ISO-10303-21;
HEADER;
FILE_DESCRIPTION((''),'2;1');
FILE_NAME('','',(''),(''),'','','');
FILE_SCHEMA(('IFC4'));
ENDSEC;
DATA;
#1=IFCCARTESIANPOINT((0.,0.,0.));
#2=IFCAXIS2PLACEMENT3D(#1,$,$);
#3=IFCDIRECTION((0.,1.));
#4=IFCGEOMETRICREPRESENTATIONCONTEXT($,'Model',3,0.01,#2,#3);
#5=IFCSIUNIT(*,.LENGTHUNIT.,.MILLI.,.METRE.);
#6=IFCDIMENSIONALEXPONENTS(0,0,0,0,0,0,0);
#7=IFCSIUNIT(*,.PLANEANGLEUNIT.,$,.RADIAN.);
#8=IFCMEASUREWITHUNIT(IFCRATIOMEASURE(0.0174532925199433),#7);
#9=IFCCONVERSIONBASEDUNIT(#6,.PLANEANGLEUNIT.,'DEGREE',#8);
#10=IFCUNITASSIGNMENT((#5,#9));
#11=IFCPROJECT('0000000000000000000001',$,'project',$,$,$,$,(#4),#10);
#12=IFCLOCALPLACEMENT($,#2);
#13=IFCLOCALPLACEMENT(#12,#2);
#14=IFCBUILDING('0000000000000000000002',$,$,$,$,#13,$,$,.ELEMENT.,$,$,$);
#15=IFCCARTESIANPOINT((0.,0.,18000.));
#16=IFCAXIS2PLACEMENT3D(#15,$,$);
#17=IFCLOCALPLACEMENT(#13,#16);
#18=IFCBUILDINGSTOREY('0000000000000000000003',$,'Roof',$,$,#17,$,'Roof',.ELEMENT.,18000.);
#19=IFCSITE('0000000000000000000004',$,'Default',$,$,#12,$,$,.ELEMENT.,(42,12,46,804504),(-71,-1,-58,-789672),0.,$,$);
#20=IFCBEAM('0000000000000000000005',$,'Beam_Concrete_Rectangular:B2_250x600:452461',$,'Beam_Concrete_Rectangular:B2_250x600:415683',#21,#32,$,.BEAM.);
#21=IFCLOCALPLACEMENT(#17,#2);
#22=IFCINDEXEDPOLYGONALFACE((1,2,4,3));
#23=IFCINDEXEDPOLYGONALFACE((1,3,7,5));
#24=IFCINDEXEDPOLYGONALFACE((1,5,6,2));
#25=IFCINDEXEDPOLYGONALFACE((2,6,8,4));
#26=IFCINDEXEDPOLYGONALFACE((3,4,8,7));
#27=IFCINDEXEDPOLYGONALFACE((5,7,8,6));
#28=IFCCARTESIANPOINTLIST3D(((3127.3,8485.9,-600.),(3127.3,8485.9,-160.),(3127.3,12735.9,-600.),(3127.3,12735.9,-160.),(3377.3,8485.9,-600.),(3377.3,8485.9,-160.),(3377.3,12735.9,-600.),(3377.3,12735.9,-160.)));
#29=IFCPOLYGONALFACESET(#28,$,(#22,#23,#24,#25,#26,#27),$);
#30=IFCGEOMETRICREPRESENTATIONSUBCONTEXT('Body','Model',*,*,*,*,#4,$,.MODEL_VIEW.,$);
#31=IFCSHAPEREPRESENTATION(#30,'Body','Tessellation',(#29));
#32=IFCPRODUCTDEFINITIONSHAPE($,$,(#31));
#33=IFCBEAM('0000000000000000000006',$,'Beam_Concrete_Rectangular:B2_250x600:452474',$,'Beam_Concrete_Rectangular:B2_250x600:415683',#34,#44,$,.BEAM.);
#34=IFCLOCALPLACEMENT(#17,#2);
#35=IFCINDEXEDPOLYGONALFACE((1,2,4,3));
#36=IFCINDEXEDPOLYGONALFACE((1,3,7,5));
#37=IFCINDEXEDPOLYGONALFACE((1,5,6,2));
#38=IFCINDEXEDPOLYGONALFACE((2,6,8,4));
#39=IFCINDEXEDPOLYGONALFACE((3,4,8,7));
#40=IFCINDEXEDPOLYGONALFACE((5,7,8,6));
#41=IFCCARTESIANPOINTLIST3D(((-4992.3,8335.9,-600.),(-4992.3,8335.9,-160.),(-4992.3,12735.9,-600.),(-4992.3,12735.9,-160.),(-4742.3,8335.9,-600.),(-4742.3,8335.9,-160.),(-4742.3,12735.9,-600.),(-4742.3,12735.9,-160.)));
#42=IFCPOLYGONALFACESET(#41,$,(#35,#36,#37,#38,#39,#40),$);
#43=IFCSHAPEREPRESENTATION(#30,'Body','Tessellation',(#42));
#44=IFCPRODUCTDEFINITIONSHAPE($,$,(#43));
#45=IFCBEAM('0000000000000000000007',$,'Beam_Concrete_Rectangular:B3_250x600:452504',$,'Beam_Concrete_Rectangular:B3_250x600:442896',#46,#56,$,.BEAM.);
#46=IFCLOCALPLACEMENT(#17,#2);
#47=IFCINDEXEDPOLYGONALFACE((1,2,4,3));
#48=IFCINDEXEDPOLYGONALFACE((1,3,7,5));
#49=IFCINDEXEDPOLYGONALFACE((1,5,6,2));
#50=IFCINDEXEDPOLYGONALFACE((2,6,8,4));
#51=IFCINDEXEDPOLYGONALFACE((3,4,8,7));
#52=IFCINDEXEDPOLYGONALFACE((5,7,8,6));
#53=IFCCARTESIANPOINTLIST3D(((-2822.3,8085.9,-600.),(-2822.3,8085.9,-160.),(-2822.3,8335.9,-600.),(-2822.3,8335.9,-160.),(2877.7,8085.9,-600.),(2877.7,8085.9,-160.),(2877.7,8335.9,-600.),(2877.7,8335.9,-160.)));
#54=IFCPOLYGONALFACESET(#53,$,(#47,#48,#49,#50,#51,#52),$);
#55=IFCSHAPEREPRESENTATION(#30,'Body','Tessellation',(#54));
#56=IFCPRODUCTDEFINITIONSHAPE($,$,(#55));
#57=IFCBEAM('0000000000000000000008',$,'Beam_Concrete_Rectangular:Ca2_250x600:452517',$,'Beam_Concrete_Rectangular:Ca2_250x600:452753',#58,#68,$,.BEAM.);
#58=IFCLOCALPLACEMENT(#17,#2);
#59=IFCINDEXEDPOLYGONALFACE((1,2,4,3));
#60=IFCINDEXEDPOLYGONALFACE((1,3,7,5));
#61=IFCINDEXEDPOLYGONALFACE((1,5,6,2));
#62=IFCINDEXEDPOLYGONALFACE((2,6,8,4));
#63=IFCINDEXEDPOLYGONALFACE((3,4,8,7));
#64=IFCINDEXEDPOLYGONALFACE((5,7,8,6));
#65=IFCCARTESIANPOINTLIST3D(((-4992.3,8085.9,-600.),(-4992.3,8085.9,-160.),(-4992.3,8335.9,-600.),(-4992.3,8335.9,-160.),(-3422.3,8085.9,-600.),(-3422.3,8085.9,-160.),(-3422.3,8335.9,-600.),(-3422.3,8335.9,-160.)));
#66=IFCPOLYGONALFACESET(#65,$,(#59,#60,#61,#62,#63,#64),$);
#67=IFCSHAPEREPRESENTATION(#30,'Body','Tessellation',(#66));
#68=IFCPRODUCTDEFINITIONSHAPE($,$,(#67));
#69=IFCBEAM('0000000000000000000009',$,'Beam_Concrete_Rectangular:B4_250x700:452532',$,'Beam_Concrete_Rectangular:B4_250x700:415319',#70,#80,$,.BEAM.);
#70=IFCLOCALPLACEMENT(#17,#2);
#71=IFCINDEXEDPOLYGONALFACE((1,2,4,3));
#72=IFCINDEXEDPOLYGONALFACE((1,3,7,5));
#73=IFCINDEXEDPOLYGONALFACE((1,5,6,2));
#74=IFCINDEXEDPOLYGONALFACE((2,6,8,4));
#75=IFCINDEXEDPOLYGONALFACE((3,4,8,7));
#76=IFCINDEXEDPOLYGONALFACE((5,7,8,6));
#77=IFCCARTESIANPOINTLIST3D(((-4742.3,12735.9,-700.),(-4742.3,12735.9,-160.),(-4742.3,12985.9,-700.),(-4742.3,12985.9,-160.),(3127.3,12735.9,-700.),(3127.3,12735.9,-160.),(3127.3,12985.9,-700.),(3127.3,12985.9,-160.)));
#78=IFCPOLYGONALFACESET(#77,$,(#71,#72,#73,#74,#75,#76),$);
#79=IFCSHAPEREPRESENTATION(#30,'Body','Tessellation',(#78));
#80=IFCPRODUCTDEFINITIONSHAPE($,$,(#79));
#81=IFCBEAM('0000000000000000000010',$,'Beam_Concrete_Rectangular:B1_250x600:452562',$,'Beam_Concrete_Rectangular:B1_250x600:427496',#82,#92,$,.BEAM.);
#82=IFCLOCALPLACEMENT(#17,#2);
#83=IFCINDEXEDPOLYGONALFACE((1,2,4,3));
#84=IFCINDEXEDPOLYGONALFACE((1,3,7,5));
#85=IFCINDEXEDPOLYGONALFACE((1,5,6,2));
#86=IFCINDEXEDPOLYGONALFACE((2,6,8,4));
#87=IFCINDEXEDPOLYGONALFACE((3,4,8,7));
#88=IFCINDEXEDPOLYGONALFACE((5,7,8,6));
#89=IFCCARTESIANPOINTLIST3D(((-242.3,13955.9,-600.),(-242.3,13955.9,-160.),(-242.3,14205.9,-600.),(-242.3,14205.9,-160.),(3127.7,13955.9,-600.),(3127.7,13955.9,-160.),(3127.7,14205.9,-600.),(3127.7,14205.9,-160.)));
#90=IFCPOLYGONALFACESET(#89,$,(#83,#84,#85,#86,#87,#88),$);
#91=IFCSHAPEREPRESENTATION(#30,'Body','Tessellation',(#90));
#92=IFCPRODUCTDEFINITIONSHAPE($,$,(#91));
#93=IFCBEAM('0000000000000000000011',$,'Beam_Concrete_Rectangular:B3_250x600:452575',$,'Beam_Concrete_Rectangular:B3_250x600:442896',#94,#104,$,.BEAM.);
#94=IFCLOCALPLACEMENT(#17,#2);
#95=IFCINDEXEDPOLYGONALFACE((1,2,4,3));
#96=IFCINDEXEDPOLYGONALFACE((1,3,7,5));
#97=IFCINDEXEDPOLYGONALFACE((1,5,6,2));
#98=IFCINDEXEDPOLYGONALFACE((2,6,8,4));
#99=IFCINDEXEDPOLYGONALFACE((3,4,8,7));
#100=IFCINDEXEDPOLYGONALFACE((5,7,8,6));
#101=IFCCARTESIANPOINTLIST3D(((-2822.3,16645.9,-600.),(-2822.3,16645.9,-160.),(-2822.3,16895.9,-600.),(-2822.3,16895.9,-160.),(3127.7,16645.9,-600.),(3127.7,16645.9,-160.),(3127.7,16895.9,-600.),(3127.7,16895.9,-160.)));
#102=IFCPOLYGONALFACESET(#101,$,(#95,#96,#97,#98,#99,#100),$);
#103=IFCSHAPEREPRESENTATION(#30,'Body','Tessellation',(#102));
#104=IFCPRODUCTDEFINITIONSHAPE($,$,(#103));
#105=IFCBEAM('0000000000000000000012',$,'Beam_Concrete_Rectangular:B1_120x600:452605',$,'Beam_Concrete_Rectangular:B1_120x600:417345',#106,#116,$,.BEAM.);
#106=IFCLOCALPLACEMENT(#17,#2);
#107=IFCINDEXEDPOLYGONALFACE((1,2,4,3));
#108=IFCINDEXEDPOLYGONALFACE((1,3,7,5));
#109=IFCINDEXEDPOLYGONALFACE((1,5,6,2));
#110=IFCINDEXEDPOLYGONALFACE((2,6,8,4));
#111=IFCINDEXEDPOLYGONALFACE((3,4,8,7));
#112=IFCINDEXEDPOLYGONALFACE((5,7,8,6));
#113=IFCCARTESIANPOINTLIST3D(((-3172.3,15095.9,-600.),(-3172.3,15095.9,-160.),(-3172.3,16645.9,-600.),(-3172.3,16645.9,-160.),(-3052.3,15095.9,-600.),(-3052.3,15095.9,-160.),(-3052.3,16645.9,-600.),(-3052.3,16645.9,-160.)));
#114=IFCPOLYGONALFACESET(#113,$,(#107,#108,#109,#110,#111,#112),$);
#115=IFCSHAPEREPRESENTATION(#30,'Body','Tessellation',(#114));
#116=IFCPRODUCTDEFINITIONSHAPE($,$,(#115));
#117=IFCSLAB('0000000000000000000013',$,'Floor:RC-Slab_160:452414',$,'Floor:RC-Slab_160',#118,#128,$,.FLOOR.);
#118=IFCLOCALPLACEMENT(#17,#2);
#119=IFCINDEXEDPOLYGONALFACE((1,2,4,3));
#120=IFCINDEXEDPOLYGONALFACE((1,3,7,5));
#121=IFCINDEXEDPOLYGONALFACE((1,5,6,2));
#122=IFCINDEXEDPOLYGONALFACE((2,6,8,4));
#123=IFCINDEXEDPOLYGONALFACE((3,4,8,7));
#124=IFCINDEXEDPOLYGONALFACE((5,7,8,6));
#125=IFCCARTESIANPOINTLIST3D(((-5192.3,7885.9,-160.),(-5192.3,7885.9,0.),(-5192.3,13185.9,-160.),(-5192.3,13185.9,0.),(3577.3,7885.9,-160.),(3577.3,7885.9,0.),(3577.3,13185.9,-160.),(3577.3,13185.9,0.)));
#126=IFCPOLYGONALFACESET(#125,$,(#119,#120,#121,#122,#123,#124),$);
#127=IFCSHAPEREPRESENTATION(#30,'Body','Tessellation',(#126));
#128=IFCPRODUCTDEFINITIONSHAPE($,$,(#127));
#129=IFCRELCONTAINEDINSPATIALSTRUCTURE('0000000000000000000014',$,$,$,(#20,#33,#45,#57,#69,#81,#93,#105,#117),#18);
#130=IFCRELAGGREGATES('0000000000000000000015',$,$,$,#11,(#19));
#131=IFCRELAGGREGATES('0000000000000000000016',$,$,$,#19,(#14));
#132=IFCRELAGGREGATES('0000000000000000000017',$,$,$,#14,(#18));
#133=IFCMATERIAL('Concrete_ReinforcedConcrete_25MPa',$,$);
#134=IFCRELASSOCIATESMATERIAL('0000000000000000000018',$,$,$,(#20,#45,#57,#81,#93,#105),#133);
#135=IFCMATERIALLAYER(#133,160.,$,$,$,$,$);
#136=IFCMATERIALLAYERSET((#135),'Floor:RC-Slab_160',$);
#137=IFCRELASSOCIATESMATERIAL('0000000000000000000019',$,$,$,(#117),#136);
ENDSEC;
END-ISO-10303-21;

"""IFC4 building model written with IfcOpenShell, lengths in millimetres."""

from ifc_helpers import new_model, entity, si_unit, converted_unit, direction, frame, frame_2d, origin, place, context, subcontext, project, spatial, rectangle, extrude, material, layer, layer_set, layer_usage, element, save


model = new_model("IFC4")

# Units and contexts
model_context = context("Model", 3, precision=0.01, world=origin(), true_north=direction((0.0, 1.0)))
body_context = subcontext(model_context, "Body", "Model", "MODEL_VIEW")
ifc_project = project(units=[si_unit("LENGTHUNIT", "METRE", prefix="MILLI"), converted_unit("PLANEANGLEUNIT", "DEGREE", entity("IfcRatioMeasure", 0.0174532925199433), si_unit("PLANEANGLEUNIT", "RADIAN"), dimensions=[0, 0, 0, 0, 0, 0, 0])], contexts=[model_context])

# Site, building, storey
site_placement = place(None, origin())
site = spatial("IfcSite", under=ifc_project, at=site_placement, Name="Default", CompositionType="ELEMENT", RefLatitude=(42, 12, 46, 804504), RefLongitude=(-71, -1, -58, -789672), RefElevation=0.0)
building_placement = place(site_placement, origin())
building = spatial("IfcBuilding", under=site, at=building_placement, CompositionType="ELEMENT")
storey_placement = place(building_placement, frame((0.0, 0.0, 18000.0)))
storey = spatial("IfcBuildingStorey", under=building, at=storey_placement, Name="Roof", LongName="Roof", CompositionType="ELEMENT", Elevation=18000.0)

# Beams
ifc_material = material(Name="Concrete_ReinforcedConcrete_25MPa")
beam_1_placement = place(storey_placement, frame((3127.3, 12860.9, 0.0), z_axis=(0.0, 0.0, 1.0), x_axis=(0.0, -1.0, 0.0)))
element("IfcBeam", 1, at=beam_1_placement, inside=storey, material=ifc_material, Name="Beam_Concrete_Rectangular:B2_250x600:452461", ObjectType="Beam_Concrete_Rectangular:B2_250x600:415683", PredefinedType="BEAM", context=body_context, shape_type="SweptSolid", body=[
    extrude(rectangle(XDim=440.0, YDim=250.0, at=frame_2d((0.0, 0.0), x_axis=(1.0, 0.0))), frame((125.0, 125.0, -380.0), z_axis=(1.0, 0.0, 0.0), x_axis=(0.0, 0.0, -1.0)), (0.0, 0.0, 1.0), 4250.0),
])
beam_2_placement = place(storey_placement, frame((-4742.3, 8335.9, 0.0), z_axis=(0.0, 0.0, 1.0), x_axis=(0.0, 1.0, 0.0)))
element("IfcBeam", 2, at=beam_2_placement, inside=storey, Name="Beam_Concrete_Rectangular:B2_250x600:452474", ObjectType="Beam_Concrete_Rectangular:B2_250x600:415683", PredefinedType="BEAM", context=body_context, shape_type="SweptSolid", body=[
    extrude(rectangle(XDim=440.0, YDim=250.0, at=frame_2d((0.0, 0.0), x_axis=(1.0, 0.0))), frame((0.0, 125.0, -380.0), z_axis=(1.0, 0.0, 0.0), x_axis=(0.0, 0.0, -1.0)), (0.0, 0.0, 1.0), 4400.0),
])
beam_3_placement = place(storey_placement, frame((-3122.3, 8085.9, 0.0)))
element("IfcBeam", 3, at=beam_3_placement, inside=storey, material=ifc_material, Name="Beam_Concrete_Rectangular:B3_250x600:452504", ObjectType="Beam_Concrete_Rectangular:B3_250x600:442896", PredefinedType="BEAM", context=body_context, shape_type="SweptSolid", body=[
    extrude(rectangle(XDim=440.0, YDim=250.0, at=frame_2d((0.0, 0.0), x_axis=(1.0, 0.0))), frame((300.0, 125.0, -380.0), z_axis=(1.0, 0.0, 0.0), x_axis=(0.0, 0.0, -1.0)), (0.0, 0.0, 1.0), 5700.0),
])
beam_4_placement = place(storey_placement, frame((-4992.3, 8085.9, 0.0)))
element("IfcBeam", 4, at=beam_4_placement, inside=storey, material=ifc_material, Name="Beam_Concrete_Rectangular:Ca2_250x600:452517", ObjectType="Beam_Concrete_Rectangular:Ca2_250x600:452753", PredefinedType="BEAM", context=body_context, shape_type="SweptSolid", body=[
    extrude(rectangle(XDim=440.0, YDim=250.0, at=frame_2d((0.0, 0.0), x_axis=(1.0, 0.0))), frame((0.0, 125.0, -380.0), z_axis=(1.0, 0.0, 0.0), x_axis=(0.0, 0.0, -1.0)), (0.0, 0.0, 1.0), 1570.0),
])
beam_5_placement = place(storey_placement, frame((-4867.3, 12735.9, 0.0)))
element("IfcBeam", 5, at=beam_5_placement, inside=storey, Name="Beam_Concrete_Rectangular:B4_250x700:452532", ObjectType="Beam_Concrete_Rectangular:B4_250x700:415319", PredefinedType="BEAM", context=body_context, shape_type="SweptSolid", body=[
    extrude(rectangle(XDim=540.0, YDim=250.0, at=frame_2d((0.0, 0.0), x_axis=(1.0, 0.0))), frame((125.0, 125.0, -430.0), z_axis=(1.0, 0.0, 0.0), x_axis=(0.0, 0.0, -1.0)), (0.0, 0.0, 1.0), 7869.6),
])
beam_6_placement = place(storey_placement, frame((-592.3, 13955.9, 0.0)))
element("IfcBeam", 6, at=beam_6_placement, inside=storey, material=ifc_material, Name="Beam_Concrete_Rectangular:B1_250x600:452562", ObjectType="Beam_Concrete_Rectangular:B1_250x600:427496", PredefinedType="BEAM", context=body_context, shape_type="SweptSolid", body=[
    extrude(rectangle(XDim=440.0, YDim=250.0, at=frame_2d((0.0, 0.0), x_axis=(1.0, 0.0))), frame((350.0, 125.0, -380.0), z_axis=(1.0, 0.0, 0.0), x_axis=(0.0, 0.0, -1.0)), (0.0, 0.0, 1.0), 3370.0),
])
beam_7_placement = place(storey_placement, frame((-3072.3, 16645.9, 0.0)))
element("IfcBeam", 7, at=beam_7_placement, inside=storey, material=ifc_material, Name="Beam_Concrete_Rectangular:B3_250x600:452575", ObjectType="Beam_Concrete_Rectangular:B3_250x600:442896", PredefinedType="BEAM", context=body_context, shape_type="SweptSolid", body=[
    extrude(rectangle(XDim=440.0, YDim=250.0, at=frame_2d((0.0, 0.0), x_axis=(1.0, 0.0))), frame((250.0, 125.0, -380.0), z_axis=(1.0, 0.0, 0.0), x_axis=(0.0, 0.0, -1.0)), (0.0, 0.0, 1.0), 5950.0),
])
beam_8_placement = place(storey_placement, frame((-3172.3, 16770.9, 0.0), z_axis=(0.0, 0.0, 1.0), x_axis=(0.0, -1.0, 0.0)))
element("IfcBeam", 8, at=beam_8_placement, inside=storey, material=ifc_material, Name="Beam_Concrete_Rectangular:B1_120x600:452605", ObjectType="Beam_Concrete_Rectangular:B1_120x600:417345", PredefinedType="BEAM", context=body_context, shape_type="SweptSolid", body=[
    extrude(rectangle(XDim=440.0, YDim=120.0, at=frame_2d((0.0, 0.0), x_axis=(1.0, 0.0))), frame((125.0, 60.0, -380.0), z_axis=(1.0, 0.0, 0.0), x_axis=(0.0, 0.0, -1.0)), (0.0, 0.0, 1.0), 1550.0),
])

# Slab
ifc_layer = layer(ifc_material, 160.0)
ifc_layer_set = layer_set([ifc_layer], Name="Floor:RC-Slab_160")
ifc_layer_usage_1 = layer_usage(ifc_layer_set, "AXIS3", "POSITIVE", 0.0)
slab_1_placement = place(storey_placement, origin())
element("IfcSlab", 9, at=slab_1_placement, inside=storey, material=ifc_layer_usage_1, Name="Floor:RC-Slab_160:452414", ObjectType="Floor:RC-Slab_160", PredefinedType="FLOOR", context=body_context, shape_type="SweptSolid", body=[
    extrude(rectangle(XDim=5300.0, YDim=8769.6, at=frame_2d((0.0, 0.0), x_axis=(1.0, 0.0))), frame((-807.5, 10535.9, 0.0), z_axis=(0.0, 0.0, -1.0), x_axis=(0.0, 1.0, 0.0)), (0.0, 0.0, 1.0), 160.0),
])

save(model, "model.ifc")
